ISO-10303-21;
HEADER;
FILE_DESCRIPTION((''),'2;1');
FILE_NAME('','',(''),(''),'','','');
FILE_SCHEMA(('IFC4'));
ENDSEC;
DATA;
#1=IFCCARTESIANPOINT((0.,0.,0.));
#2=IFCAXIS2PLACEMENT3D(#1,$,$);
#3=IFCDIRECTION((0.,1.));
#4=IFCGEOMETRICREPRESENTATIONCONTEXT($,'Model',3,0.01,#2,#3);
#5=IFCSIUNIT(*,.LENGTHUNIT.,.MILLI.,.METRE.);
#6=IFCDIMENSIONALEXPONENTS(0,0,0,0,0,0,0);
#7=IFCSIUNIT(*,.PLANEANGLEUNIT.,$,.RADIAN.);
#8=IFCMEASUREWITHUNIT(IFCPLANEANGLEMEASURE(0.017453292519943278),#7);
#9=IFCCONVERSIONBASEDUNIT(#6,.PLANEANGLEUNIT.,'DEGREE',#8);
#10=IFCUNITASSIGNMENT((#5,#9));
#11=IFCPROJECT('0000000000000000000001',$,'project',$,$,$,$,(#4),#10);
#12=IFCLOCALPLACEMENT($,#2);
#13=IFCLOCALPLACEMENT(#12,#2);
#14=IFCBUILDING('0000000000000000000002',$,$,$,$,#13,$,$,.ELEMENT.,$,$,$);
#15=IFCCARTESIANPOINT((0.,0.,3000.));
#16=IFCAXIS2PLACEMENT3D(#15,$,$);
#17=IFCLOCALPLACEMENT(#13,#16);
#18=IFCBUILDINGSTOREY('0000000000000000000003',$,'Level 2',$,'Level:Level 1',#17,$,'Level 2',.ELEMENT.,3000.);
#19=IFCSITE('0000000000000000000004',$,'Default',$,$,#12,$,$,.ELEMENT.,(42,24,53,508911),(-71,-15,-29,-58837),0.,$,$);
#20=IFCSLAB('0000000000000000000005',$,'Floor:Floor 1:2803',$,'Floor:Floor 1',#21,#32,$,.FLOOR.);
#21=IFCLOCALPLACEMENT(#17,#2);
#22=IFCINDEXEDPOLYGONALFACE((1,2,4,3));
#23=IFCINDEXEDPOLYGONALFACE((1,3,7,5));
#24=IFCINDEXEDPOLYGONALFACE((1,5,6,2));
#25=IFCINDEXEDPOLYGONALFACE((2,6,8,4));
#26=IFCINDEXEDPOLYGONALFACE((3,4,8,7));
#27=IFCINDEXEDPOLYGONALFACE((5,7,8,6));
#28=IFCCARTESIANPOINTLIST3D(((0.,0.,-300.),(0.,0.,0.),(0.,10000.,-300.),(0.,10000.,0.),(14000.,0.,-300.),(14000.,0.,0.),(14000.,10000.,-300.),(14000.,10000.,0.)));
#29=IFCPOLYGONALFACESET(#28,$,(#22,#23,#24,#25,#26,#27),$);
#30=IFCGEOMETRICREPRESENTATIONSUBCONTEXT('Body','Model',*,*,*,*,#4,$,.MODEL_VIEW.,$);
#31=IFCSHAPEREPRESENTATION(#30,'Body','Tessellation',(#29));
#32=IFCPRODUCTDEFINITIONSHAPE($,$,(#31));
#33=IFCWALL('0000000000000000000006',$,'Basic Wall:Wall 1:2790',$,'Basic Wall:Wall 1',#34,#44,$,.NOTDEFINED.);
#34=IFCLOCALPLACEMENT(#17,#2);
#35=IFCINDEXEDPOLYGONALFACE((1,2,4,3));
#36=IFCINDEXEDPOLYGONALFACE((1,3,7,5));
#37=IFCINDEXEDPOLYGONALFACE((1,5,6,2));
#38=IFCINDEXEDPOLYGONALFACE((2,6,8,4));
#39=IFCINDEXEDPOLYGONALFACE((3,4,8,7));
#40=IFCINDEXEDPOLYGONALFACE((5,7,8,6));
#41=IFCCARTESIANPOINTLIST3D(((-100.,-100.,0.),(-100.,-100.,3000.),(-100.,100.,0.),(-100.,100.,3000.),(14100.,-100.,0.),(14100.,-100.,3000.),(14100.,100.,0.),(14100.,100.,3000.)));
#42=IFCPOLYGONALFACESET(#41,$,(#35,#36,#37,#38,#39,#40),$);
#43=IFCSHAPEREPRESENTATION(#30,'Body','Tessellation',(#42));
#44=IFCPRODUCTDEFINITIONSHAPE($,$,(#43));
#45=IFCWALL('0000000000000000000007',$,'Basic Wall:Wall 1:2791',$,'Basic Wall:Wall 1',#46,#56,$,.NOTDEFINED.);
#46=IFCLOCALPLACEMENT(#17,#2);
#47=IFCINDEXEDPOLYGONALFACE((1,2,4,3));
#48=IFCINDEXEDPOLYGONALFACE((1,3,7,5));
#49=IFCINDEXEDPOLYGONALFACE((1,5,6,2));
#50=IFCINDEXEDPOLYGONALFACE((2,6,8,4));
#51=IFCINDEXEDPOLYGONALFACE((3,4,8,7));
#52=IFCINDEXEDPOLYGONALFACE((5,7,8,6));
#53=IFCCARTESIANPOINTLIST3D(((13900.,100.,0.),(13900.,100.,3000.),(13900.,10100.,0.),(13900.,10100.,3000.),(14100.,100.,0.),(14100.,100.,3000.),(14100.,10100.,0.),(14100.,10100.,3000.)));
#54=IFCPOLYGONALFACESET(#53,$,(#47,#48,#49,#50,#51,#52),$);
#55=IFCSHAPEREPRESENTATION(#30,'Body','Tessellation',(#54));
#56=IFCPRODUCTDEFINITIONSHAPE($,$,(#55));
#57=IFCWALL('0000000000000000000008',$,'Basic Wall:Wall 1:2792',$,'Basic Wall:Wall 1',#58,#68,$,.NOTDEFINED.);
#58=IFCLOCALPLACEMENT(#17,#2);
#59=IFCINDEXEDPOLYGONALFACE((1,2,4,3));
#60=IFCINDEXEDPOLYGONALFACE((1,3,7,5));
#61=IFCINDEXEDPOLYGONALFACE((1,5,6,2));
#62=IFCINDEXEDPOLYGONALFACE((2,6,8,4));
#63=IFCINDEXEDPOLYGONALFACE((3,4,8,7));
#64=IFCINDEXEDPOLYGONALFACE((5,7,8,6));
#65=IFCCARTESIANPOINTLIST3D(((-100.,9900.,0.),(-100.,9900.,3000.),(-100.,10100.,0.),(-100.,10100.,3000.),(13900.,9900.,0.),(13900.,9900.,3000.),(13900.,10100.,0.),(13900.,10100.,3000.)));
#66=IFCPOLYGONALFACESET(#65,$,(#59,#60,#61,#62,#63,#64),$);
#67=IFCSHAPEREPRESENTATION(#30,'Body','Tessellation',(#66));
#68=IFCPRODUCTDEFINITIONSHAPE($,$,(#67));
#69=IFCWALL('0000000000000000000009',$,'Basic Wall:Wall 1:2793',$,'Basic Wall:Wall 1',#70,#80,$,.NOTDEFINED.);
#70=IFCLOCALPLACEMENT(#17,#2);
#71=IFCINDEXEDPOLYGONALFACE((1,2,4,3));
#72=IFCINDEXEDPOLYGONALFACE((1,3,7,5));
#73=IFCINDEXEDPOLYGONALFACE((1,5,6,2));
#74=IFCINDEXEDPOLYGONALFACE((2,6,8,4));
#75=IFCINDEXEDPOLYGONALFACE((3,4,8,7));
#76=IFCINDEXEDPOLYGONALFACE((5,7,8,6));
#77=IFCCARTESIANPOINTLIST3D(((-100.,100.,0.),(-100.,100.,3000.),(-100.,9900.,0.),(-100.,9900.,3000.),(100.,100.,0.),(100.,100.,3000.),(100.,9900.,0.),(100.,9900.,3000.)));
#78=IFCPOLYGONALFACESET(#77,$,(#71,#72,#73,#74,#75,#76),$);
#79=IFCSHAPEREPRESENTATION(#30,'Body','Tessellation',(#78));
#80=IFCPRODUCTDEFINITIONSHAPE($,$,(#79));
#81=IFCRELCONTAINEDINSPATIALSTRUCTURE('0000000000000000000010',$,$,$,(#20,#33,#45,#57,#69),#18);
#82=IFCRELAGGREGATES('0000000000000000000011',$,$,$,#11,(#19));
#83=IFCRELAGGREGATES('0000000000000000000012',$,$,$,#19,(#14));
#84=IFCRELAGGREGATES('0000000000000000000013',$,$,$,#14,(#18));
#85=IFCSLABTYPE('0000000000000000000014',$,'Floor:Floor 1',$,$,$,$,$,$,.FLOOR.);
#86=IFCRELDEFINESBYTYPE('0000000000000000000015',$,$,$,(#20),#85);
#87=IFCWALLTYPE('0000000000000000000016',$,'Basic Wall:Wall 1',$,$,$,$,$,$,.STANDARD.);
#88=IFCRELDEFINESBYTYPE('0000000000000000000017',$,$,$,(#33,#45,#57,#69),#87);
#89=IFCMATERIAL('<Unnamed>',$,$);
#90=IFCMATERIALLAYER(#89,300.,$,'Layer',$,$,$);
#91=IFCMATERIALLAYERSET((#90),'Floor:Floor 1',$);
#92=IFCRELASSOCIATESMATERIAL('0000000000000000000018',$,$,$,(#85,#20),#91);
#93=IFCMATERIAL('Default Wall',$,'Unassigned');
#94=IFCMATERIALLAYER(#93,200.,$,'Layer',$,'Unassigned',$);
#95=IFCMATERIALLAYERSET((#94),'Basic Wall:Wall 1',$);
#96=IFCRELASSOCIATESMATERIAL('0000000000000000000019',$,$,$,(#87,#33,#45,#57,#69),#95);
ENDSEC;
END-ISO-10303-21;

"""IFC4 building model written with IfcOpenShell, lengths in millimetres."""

from ifc_helpers import new_model, entity, si_unit, converted_unit, direction, frame, frame_2d, origin, origin_2d_with_axis, place, context, subcontext, project, spatial, rectangle, extrude, material, layer, layer_set, layer_usage, type_object, element, save


model = new_model("IFC4")

# Units and contexts
model_context = context("Model", 3, precision=0.01, world=origin(), true_north=direction((0.0, 1.0)))
body_context = subcontext(model_context, "Body", "Model", "MODEL_VIEW")
ifc_project = project(units=[si_unit("LENGTHUNIT", "METRE", prefix="MILLI"), converted_unit("PLANEANGLEUNIT", "DEGREE", entity("IfcPlaneAngleMeasure", 0.017453292519943278), si_unit("PLANEANGLEUNIT", "RADIAN"), dimensions=[0, 0, 0, 0, 0, 0, 0])], contexts=[model_context])

# Site, building, storey
site_placement = place(None, origin())
site = spatial("IfcSite", under=ifc_project, at=site_placement, Name="Default", CompositionType="ELEMENT", RefLatitude=(42, 24, 53, 508911), RefLongitude=(-71, -15, -29, -58837), RefElevation=0.0)
building_placement = place(site_placement, origin())
building = spatial("IfcBuilding", under=site, at=building_placement, CompositionType="ELEMENT")
storey_placement = place(building_placement, frame((0.0, 0.0, 3000.0)))
storey = spatial("IfcBuildingStorey", under=building, at=storey_placement, Name="Level 2", ObjectType="Level:Level 1", LongName="Level 2", CompositionType="ELEMENT", Elevation=3000.0)

# Slab
ifc_material_1 = material(Name="<Unnamed>")
ifc_layer_1 = layer(ifc_material_1, 300.0, Name="Layer")
ifc_layer_set_1 = layer_set([ifc_layer_1], Name="Floor:Floor 1")
ifc_layer_usage_1 = layer_usage(ifc_layer_set_1, "AXIS3", "POSITIVE", 0.0)
slab_type = type_object("IfcSlabType", Name="Floor:Floor 1", PredefinedType="FLOOR", material=ifc_layer_set_1)
slab_placement = place(storey_placement, origin())
element("IfcSlab", 1, at=slab_placement, inside=storey, type_object=slab_type, material=ifc_layer_usage_1, Name="Floor:Floor 1:2803", ObjectType="Floor:Floor 1", PredefinedType="FLOOR", context=body_context, shape_type="SweptSolid", body=[
    extrude(rectangle(XDim=10000.0, YDim=14000.0, at=origin_2d_with_axis()), frame((7000.0, 5000.0, 0.0), z_axis=(0.0, 0.0, -1.0), x_axis=(0.0, 1.0, 0.0)), (0.0, 0.0, 1.0), 300.0),
])

# Walls
ifc_material_2 = material(Name="Default Wall", Category="Unassigned")
ifc_layer_2 = layer(ifc_material_2, 200.0, Name="Layer", Category="Unassigned")
ifc_layer_set_2 = layer_set([ifc_layer_2], Name="Basic Wall:Wall 1")
ifc_layer_usage_2 = layer_usage(ifc_layer_set_2, "AXIS2", "NEGATIVE", 100.0)
wall_type = type_object("IfcWallType", Name="Basic Wall:Wall 1", PredefinedType="STANDARD", material=ifc_layer_set_2)
wall_1_placement = place(storey_placement, frame((-100.0, 0.0, 0.0)))
element("IfcWall", 2, at=wall_1_placement, inside=storey, type_object=wall_type, material=ifc_layer_usage_2, Name="Basic Wall:Wall 1:2790", ObjectType="Basic Wall:Wall 1", PredefinedType="NOTDEFINED", context=body_context, shape_type="SweptSolid", body=[
    extrude(rectangle(XDim=14200.0, YDim=200.0, at=frame_2d((7100.0, 0.0), x_axis=(-1.0, 0.0))), origin(), (0.0, 0.0, 1.0), 3000.0),
])
ifc_layer_usage_3 = layer_usage(ifc_layer_set_2, "AXIS2", "NEGATIVE", 100.0)
wall_2_placement = place(storey_placement, frame((14000.0, 100.0, 0.0), z_axis=(0.0, 0.0, 1.0), x_axis=(0.0, 1.0, 0.0)))
element("IfcWall", 3, at=wall_2_placement, inside=storey, type_object=wall_type, material=ifc_layer_usage_3, Name="Basic Wall:Wall 1:2791", ObjectType="Basic Wall:Wall 1", PredefinedType="NOTDEFINED", context=body_context, shape_type="SweptSolid", body=[
    extrude(rectangle(XDim=10000.0, YDim=200.0, at=frame_2d((5000.0, 0.0), x_axis=(-1.0, 0.0))), origin(), (0.0, 0.0, 1.0), 3000.0),
])
ifc_layer_usage_4 = layer_usage(ifc_layer_set_2, "AXIS2", "NEGATIVE", 100.0)
wall_3_placement = place(storey_placement, frame((13900.0, 10000.0, 0.0), z_axis=(0.0, 0.0, 1.0), x_axis=(-1.0, 0.0, 0.0)))
element("IfcWall", 4, at=wall_3_placement, inside=storey, type_object=wall_type, material=ifc_layer_usage_4, Name="Basic Wall:Wall 1:2792", ObjectType="Basic Wall:Wall 1", PredefinedType="NOTDEFINED", context=body_context, shape_type="SweptSolid", body=[
    extrude(rectangle(XDim=14000.0, YDim=200.0, at=frame_2d((7000.0, 0.0), x_axis=(-1.0, 0.0))), origin(), (0.0, 0.0, 1.0), 3000.0),
])
ifc_layer_usage_5 = layer_usage(ifc_layer_set_2, "AXIS2", "NEGATIVE", 100.0)
wall_4_placement = place(storey_placement, frame((0.0, 9900.0, 0.0), z_axis=(0.0, 0.0, 1.0), x_axis=(0.0, -1.0, 0.0)))
element("IfcWall", 5, at=wall_4_placement, inside=storey, type_object=wall_type, material=ifc_layer_usage_5, Name="Basic Wall:Wall 1:2793", ObjectType="Basic Wall:Wall 1", PredefinedType="NOTDEFINED", context=body_context, shape_type="SweptSolid", body=[
    extrude(rectangle(XDim=9800.0, YDim=200.0, at=frame_2d((4900.0, 0.0), x_axis=(-1.0, 0.0))), origin(), (0.0, 0.0, 1.0), 3000.0),
])

save(model, "model.ifc")
